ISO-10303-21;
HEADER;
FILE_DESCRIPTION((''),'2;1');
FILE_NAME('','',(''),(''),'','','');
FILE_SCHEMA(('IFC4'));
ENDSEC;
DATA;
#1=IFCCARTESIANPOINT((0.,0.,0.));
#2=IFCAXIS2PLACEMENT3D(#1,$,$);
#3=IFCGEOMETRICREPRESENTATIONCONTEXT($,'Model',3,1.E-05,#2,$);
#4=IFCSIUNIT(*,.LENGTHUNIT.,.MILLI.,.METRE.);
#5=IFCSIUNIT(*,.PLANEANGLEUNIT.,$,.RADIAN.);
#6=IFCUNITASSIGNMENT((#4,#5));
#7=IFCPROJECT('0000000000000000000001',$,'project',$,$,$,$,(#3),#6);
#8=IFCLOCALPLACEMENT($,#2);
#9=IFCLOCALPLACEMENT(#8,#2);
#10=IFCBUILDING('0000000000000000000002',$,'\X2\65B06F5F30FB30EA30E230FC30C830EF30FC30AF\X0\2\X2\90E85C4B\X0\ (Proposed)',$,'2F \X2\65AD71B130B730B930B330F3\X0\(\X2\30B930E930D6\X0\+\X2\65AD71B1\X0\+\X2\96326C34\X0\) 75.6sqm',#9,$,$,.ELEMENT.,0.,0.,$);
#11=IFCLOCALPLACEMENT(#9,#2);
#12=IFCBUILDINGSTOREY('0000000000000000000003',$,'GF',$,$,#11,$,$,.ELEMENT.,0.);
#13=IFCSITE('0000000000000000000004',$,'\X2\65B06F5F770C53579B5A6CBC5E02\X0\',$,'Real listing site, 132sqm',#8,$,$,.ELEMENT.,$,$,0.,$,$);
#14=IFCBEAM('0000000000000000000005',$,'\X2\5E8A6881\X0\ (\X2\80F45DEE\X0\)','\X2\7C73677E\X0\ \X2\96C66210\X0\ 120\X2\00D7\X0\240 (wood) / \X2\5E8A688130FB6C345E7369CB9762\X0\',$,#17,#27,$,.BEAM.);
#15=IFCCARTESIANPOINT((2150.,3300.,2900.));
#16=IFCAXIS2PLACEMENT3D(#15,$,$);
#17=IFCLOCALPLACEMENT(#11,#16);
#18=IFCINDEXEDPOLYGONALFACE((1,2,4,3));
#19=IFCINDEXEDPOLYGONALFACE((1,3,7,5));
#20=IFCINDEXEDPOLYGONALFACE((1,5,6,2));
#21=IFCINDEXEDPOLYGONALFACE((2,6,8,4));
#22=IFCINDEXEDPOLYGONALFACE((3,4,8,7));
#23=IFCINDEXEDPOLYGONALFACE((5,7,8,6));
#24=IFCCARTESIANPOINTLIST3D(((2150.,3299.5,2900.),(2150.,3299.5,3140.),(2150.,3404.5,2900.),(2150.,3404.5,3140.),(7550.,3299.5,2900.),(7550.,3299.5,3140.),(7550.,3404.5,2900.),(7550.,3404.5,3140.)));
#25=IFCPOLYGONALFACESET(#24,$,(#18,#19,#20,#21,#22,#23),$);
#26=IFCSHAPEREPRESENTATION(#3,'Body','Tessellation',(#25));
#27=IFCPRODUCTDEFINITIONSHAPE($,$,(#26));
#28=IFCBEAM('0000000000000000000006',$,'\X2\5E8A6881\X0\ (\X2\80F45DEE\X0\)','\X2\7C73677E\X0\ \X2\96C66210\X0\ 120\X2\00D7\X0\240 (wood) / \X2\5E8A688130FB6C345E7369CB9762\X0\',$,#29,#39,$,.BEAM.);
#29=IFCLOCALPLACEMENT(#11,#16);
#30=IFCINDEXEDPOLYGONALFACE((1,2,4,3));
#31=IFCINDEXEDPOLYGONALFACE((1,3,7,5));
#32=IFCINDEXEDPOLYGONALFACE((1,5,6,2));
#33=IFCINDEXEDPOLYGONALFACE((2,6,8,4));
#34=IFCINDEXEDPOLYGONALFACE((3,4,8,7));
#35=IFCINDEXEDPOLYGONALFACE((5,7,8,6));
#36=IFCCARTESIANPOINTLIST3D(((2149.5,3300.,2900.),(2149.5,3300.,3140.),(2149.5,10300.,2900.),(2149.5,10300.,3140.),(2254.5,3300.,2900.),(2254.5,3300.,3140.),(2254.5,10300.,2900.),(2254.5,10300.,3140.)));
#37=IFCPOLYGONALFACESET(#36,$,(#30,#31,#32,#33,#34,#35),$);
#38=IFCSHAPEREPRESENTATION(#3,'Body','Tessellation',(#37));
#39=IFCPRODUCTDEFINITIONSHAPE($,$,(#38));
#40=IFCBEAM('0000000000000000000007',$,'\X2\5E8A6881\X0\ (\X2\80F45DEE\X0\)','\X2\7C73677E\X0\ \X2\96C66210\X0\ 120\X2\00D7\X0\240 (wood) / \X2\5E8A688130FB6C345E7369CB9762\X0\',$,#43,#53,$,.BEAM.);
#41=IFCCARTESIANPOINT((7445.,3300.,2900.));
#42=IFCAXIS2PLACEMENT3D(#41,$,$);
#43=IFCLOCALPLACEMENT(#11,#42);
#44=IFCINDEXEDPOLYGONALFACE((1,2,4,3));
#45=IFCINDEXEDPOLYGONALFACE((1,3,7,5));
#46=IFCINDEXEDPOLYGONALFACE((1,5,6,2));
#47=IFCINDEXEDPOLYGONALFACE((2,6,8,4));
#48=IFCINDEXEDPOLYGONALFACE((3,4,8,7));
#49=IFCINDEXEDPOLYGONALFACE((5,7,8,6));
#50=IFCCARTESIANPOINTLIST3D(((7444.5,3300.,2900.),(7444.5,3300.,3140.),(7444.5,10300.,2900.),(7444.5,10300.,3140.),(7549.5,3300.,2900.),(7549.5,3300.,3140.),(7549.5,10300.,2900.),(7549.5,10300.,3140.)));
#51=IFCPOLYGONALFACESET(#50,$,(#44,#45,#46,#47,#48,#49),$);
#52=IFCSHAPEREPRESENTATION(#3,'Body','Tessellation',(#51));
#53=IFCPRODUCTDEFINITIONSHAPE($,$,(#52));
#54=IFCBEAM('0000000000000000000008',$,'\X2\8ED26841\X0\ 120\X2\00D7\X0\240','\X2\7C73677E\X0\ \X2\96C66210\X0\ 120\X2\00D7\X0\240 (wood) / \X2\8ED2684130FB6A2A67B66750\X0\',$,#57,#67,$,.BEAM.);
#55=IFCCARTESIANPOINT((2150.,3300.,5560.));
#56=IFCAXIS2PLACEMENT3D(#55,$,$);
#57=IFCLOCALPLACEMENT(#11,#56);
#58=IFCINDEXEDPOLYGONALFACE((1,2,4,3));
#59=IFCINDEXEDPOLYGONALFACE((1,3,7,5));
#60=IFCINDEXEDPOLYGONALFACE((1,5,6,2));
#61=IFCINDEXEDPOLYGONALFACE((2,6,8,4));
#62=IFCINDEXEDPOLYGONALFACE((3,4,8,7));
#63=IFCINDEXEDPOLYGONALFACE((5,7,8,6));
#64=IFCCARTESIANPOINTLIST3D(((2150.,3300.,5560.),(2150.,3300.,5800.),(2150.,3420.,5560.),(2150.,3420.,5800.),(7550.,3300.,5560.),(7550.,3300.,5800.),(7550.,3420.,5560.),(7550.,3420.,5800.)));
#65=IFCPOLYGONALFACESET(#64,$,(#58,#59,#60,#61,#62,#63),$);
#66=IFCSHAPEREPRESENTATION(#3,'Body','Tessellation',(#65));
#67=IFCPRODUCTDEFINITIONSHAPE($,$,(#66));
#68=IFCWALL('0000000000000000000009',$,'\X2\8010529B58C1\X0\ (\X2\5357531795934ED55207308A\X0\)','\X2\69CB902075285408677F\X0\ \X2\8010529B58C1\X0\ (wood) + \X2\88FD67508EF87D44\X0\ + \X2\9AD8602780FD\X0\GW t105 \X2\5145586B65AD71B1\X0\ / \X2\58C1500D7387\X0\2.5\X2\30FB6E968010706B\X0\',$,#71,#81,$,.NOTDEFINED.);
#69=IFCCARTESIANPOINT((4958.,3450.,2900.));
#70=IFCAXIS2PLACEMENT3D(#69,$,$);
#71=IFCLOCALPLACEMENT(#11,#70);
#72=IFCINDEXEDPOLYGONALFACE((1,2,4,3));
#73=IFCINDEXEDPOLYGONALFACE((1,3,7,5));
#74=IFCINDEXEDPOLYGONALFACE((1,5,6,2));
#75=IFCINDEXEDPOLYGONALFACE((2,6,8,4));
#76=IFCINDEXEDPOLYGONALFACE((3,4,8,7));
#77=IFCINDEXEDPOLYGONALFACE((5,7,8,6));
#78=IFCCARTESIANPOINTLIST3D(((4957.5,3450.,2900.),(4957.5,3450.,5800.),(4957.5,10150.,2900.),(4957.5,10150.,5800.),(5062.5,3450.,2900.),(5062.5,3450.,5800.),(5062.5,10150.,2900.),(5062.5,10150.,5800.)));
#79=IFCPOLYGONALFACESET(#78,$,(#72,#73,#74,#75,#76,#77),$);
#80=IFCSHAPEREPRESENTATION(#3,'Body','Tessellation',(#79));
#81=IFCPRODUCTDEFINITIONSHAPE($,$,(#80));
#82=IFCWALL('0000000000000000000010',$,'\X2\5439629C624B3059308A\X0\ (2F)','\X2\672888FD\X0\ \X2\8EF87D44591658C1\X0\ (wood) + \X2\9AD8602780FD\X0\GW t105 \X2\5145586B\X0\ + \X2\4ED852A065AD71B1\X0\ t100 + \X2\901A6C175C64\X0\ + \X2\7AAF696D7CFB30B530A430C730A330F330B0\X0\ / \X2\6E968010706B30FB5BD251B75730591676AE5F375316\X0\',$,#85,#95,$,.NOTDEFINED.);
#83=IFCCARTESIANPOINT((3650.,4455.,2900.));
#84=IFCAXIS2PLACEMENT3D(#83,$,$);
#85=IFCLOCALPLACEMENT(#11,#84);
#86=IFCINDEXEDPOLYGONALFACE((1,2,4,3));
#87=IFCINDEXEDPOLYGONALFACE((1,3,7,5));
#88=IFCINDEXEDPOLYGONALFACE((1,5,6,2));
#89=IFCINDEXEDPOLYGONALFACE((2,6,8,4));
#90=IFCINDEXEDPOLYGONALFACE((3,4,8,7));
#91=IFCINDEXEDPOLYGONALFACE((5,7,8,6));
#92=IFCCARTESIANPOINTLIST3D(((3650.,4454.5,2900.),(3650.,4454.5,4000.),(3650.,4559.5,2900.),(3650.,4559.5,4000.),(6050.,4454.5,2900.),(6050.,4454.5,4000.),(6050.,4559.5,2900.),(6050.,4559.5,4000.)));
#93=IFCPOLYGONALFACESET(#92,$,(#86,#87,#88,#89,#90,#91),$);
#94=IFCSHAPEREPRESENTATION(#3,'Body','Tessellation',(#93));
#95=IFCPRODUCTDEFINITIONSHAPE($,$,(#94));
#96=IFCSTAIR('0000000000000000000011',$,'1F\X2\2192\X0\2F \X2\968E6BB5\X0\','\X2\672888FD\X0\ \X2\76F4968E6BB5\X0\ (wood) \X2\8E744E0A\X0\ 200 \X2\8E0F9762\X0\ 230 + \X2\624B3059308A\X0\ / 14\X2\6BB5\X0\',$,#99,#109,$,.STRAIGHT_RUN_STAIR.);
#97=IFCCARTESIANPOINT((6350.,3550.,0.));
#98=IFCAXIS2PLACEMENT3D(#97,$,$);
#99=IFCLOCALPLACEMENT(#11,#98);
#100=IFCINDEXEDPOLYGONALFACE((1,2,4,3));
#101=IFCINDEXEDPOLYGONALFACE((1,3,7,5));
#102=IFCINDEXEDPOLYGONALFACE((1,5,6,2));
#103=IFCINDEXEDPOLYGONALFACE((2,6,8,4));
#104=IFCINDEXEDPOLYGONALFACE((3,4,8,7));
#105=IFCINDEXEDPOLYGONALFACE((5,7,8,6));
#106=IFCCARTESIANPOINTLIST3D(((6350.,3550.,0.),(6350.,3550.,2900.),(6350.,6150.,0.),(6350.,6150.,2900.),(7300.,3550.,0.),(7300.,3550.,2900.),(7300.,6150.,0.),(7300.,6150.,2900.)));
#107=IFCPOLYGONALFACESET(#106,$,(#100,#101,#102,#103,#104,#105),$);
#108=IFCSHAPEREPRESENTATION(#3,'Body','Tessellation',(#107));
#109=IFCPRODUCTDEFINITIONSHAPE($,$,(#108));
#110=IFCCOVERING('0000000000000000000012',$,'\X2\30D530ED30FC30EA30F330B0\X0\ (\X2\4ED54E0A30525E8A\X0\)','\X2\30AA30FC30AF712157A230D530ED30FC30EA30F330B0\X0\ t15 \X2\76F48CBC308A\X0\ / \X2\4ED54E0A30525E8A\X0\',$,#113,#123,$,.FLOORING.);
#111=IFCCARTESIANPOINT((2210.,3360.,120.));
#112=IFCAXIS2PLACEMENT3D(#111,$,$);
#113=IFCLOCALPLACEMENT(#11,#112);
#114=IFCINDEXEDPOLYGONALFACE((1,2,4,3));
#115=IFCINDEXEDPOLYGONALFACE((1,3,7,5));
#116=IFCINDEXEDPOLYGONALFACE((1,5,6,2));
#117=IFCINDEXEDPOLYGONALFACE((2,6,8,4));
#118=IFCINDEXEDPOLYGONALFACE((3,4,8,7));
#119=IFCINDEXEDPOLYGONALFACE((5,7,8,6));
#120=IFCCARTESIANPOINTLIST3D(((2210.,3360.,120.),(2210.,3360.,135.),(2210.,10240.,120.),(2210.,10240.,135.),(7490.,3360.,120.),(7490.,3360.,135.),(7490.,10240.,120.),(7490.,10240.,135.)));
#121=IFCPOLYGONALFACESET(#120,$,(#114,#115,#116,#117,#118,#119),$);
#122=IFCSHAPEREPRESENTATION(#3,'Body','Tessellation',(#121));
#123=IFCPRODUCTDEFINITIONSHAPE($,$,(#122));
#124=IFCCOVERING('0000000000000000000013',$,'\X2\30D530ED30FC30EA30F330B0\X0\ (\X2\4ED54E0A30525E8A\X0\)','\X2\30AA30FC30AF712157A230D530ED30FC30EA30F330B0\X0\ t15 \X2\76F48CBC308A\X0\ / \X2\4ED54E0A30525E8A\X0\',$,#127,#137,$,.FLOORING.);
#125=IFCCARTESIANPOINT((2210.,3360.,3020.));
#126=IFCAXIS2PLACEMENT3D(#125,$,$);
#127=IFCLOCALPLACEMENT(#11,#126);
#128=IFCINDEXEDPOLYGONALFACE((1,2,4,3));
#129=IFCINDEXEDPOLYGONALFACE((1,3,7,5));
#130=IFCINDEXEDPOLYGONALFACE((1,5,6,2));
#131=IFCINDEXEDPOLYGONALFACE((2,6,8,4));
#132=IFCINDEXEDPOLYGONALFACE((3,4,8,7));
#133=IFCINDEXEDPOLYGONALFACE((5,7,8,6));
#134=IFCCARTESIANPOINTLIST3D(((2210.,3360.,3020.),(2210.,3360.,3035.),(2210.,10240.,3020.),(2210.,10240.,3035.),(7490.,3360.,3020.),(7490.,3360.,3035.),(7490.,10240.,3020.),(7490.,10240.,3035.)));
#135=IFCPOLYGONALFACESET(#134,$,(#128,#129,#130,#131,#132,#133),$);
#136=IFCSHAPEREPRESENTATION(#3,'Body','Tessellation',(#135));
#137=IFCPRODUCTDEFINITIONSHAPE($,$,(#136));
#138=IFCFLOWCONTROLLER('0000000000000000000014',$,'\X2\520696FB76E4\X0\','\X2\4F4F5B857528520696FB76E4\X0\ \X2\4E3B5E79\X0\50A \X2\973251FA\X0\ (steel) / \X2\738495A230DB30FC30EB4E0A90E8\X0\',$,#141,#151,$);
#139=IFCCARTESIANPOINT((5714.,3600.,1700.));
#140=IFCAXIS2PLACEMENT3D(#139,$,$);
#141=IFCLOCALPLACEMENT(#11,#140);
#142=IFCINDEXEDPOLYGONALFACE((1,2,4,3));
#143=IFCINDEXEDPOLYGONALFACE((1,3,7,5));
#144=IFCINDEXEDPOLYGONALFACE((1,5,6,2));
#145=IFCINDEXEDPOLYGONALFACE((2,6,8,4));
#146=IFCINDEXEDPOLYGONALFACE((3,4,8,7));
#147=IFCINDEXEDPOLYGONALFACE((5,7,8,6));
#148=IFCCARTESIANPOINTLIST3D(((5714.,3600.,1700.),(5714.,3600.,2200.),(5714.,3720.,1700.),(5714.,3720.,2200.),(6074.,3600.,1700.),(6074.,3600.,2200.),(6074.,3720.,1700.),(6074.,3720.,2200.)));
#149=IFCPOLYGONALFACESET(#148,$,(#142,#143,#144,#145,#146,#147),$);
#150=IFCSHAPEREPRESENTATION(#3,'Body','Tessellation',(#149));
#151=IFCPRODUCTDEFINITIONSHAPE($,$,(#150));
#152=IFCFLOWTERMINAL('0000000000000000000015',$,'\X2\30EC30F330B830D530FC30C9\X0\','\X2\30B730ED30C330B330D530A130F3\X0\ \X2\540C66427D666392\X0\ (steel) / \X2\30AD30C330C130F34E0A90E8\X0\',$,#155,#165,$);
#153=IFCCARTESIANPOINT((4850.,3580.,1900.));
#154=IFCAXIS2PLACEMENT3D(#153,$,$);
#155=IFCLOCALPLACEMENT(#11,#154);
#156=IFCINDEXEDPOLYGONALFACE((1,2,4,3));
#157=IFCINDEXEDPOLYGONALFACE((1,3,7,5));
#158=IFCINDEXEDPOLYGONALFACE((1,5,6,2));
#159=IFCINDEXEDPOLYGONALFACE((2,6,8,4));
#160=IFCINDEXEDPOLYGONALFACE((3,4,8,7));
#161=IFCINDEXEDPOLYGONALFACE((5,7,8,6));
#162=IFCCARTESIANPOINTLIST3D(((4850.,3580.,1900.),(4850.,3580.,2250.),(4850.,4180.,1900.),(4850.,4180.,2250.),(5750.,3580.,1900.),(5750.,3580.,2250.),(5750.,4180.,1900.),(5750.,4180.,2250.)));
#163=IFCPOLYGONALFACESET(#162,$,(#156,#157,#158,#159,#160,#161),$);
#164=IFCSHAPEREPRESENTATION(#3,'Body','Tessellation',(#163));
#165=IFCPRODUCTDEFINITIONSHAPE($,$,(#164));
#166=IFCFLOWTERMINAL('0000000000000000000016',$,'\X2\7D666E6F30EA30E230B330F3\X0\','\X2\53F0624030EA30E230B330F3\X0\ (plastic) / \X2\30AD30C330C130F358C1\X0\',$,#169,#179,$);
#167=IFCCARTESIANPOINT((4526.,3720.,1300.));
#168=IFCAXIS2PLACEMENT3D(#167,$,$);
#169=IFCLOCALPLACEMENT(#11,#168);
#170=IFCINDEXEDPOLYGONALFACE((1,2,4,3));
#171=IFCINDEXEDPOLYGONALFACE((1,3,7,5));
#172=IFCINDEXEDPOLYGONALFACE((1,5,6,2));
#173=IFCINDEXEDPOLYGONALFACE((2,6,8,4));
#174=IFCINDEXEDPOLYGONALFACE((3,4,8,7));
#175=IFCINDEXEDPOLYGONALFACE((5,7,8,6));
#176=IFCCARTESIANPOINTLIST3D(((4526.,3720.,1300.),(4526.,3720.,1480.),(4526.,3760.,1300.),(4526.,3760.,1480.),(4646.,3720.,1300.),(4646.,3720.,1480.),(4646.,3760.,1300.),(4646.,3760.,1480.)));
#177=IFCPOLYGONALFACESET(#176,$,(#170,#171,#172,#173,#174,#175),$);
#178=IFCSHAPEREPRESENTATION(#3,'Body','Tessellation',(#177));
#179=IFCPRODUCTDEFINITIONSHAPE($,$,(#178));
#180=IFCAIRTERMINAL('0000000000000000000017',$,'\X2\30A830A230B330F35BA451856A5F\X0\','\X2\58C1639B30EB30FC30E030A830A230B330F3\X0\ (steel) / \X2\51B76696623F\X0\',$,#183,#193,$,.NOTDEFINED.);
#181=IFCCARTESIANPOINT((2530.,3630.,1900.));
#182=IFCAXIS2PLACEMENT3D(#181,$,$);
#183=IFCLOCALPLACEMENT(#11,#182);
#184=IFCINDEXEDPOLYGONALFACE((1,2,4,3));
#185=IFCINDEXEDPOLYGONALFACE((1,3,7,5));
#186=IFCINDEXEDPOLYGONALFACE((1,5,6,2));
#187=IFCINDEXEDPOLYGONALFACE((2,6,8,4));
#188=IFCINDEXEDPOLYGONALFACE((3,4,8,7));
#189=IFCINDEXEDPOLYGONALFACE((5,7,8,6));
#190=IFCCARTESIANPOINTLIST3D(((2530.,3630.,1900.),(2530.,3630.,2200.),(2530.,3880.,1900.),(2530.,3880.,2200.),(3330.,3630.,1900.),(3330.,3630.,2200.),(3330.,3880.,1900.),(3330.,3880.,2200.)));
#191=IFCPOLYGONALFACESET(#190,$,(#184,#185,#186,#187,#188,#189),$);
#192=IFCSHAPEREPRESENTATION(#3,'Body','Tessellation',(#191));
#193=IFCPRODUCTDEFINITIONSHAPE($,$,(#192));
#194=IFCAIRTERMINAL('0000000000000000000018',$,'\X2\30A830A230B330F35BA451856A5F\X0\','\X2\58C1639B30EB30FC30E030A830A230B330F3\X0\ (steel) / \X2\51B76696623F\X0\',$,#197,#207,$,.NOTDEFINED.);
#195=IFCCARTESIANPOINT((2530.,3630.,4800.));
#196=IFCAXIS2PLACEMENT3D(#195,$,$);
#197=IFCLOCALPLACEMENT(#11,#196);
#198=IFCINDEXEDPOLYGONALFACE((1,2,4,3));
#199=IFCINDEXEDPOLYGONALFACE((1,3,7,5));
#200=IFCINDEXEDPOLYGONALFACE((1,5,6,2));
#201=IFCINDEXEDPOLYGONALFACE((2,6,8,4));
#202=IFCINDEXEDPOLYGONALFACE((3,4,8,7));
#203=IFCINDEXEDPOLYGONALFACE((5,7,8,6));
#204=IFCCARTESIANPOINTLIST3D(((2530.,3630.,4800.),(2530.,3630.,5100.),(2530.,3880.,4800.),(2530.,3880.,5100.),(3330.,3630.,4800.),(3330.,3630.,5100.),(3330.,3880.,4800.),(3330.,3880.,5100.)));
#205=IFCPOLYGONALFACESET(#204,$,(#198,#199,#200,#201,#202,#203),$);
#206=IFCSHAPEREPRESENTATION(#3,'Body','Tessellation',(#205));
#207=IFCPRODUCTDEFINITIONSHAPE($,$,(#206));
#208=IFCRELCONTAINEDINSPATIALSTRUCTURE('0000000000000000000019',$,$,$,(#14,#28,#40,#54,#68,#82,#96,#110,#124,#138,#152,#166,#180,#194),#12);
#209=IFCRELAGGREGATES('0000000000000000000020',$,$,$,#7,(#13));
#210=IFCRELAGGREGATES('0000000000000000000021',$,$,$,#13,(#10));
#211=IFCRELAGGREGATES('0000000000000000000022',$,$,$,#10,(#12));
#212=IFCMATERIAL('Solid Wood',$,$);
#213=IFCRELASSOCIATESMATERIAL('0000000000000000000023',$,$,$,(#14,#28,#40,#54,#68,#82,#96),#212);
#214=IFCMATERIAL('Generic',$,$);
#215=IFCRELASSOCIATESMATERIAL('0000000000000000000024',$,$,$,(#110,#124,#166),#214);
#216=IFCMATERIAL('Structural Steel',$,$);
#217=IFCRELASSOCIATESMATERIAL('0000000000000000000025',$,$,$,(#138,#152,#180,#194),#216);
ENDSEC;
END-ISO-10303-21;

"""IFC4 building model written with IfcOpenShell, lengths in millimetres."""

from ifc_helpers import new_model, si_unit, frame, frame_2d, origin, place, context, project, spatial, rectangle, extrude, material, element, save


model = new_model("IFC4")

# Units and contexts
model_context = context("Model", 3, precision=1e-05, world=origin())
ifc_project = project(units=[si_unit("LENGTHUNIT", "METRE", prefix="MILLI"), si_unit("PLANEANGLEUNIT", "RADIAN")], contexts=[model_context])

# Site, building, storey
site_placement = place(None, origin())
site = spatial("IfcSite", under=ifc_project, at=site_placement, Name="新潟県南魚沼市", ObjectType="Real listing site, 132sqm", CompositionType="ELEMENT", RefElevation=0.0)
building_placement = place(site_placement, origin())
building = spatial("IfcBuilding", under=site, at=building_placement, Name="新潟・リモートワーク2部屋 (Proposed)", ObjectType="2F 断熱シスコン(スラブ+断熱+防水) 75.6sqm", CompositionType="ELEMENT", ElevationOfRefHeight=0.0, ElevationOfTerrain=0.0)
storey_placement = place(building_placement, origin())
storey = spatial("IfcBuildingStorey", under=building, at=storey_placement, Name="GF", CompositionType="ELEMENT", Elevation=0.0)

# Shared definitions
ifc_material_1 = material(Name="Solid Wood")

# Beams
beam_1_placement = place(storey_placement, frame((2150.0, 3300.0, 2900.0)))
element("IfcBeam", 1, at=beam_1_placement, inside=storey, material=ifc_material_1, Name="床梁 (胴差)", Description="米松 集成 120×240 (wood) / 床梁・水平構面", PredefinedType="BEAM", context=model_context, shape_type="SweptSolid", body=[
    extrude(rectangle(XDim=5400.0, YDim=105.0, at=frame_2d((2700.0, 52.0))), frame((2150.0, 3300.0, 2900.0)), (0.0, 0.0, 1.0), 240.0),
])
beam_2_placement = place(storey_placement, frame((2150.0, 3300.0, 2900.0)))
element("IfcBeam", 2, at=beam_2_placement, inside=storey, material=ifc_material_1, Name="床梁 (胴差)", Description="米松 集成 120×240 (wood) / 床梁・水平構面", PredefinedType="BEAM", context=model_context, shape_type="SweptSolid", body=[
    extrude(rectangle(XDim=105.0, YDim=7000.0, at=frame_2d((52.0, 3500.0))), frame((2150.0, 3300.0, 2900.0)), (0.0, 0.0, 1.0), 240.0),
])
beam_3_placement = place(storey_placement, frame((7445.0, 3300.0, 2900.0)))
element("IfcBeam", 3, at=beam_3_placement, inside=storey, material=ifc_material_1, Name="床梁 (胴差)", Description="米松 集成 120×240 (wood) / 床梁・水平構面", PredefinedType="BEAM", context=model_context, shape_type="SweptSolid", body=[
    extrude(rectangle(XDim=105.0, YDim=7000.0, at=frame_2d((52.0, 3500.0))), frame((7445.0, 3300.0, 2900.0)), (0.0, 0.0, 1.0), 240.0),
])
beam_4_placement = place(storey_placement, frame((2150.0, 3300.0, 5560.0)))
element("IfcBeam", 4, at=beam_4_placement, inside=storey, material=ifc_material_1, Name="軒桁 120×240", Description="米松 集成 120×240 (wood) / 軒桁・横架材", PredefinedType="BEAM", context=model_context, shape_type="SweptSolid", body=[
    extrude(rectangle(XDim=5400.0, YDim=120.0, at=frame_2d((2700.0, 60.0))), frame((2150.0, 3300.0, 5560.0)), (0.0, 0.0, 1.0), 240.0),
])

# Walls
wall_1_placement = place(storey_placement, frame((4958.0, 3450.0, 2900.0)))
element("IfcWall", 5, at=wall_1_placement, inside=storey, material=ifc_material_1, Name="耐力壁 (南北間仕切り)", Description="構造用合板 耐力壁 (wood) + 製材軸組 + 高性能GW t105 充填断熱 / 壁倍率2.5・準耐火", PredefinedType="NOTDEFINED", context=model_context, shape_type="SweptSolid", body=[
    extrude(rectangle(XDim=105.0, YDim=6700.0, at=frame_2d((52.0, 3350.0))), frame((4958.0, 3450.0, 2900.0)), (0.0, 0.0, 1.0), 2900.0),
])
wall_2_placement = place(storey_placement, frame((3650.0, 4455.0, 2900.0)))
element("IfcWall", 6, at=wall_2_placement, inside=storey, material=ifc_material_1, Name="吹抜手すり (2F)", Description="木製 軸組外壁 (wood) + 高性能GW t105 充填 + 付加断熱 t100 + 通気層 + 窯業系サイディング / 準耐火・寒冷地外皮強化", PredefinedType="NOTDEFINED", context=model_context, shape_type="SweptSolid", body=[
    extrude(rectangle(XDim=2400.0, YDim=105.0, at=frame_2d((1200.0, 52.0))), frame((3650.0, 4455.0, 2900.0)), (0.0, 0.0, 1.0), 1100.0),
])

# Stair
stair_placement = place(storey_placement, frame((6350.0, 3550.0, 0.0)))
element("IfcStair", 7, at=stair_placement, inside=storey, material=ifc_material_1, Name="1F→2F 階段", Description="木製 直階段 (wood) 蹴上 200 踏面 230 + 手すり / 14段", PredefinedType="STRAIGHT_RUN_STAIR", context=model_context, shape_type="SweptSolid", body=[
    extrude(rectangle(XDim=950.0, YDim=2600.0, at=frame_2d((475.0, 1300.0))), frame((6350.0, 3550.0, 0.0)), (0.0, 0.0, 1.0), 2900.0),
])

# Coverings
ifc_material_2 = material(Name="Generic")
covering_1_placement = place(storey_placement, frame((2210.0, 3360.0, 120.0)))
element("IfcCovering", 8, at=covering_1_placement, inside=storey, material=ifc_material_2, Name="フローリング (仕上げ床)", Description="オーク無垢フローリング t15 直貼り / 仕上げ床", PredefinedType="FLOORING", context=model_context, shape_type="SweptSolid", body=[
    extrude(rectangle(XDim=5280.0, YDim=6880.0, at=frame_2d((2640.0, 3440.0))), frame((2210.0, 3360.0, 120.0)), (0.0, 0.0, 1.0), 15.0),
])
covering_2_placement = place(storey_placement, frame((2210.0, 3360.0, 3020.0)))
element("IfcCovering", 9, at=covering_2_placement, inside=storey, material=ifc_material_2, Name="フローリング (仕上げ床)", Description="オーク無垢フローリング t15 直貼り / 仕上げ床", PredefinedType="FLOORING", context=model_context, shape_type="SweptSolid", body=[
    extrude(rectangle(XDim=5280.0, YDim=6880.0, at=frame_2d((2640.0, 3440.0))), frame((2210.0, 3360.0, 3020.0)), (0.0, 0.0, 1.0), 15.0),
])

# Flow controller
ifc_material_3 = material(Name="Structural Steel")
flow_controller_placement = place(storey_placement, frame((5714.0, 3600.0, 1700.0)))
element("IfcFlowController", 10, at=flow_controller_placement, inside=storey, material=ifc_material_3, Name="分電盤", Description="住宅用分電盤 主幹50A 露出 (steel) / 玄関ホール上部", context=model_context, shape_type="SweptSolid", body=[
    extrude(rectangle(XDim=360.0, YDim=120.0, at=frame_2d((180.0, 60.0))), frame((5714.0, 3600.0, 1700.0)), (0.0, 0.0, 1.0), 500.0),
])

# Flow terminals
flow_terminal_1_placement = place(storey_placement, frame((4850.0, 3580.0, 1900.0)))
element("IfcFlowTerminal", 11, at=flow_terminal_1_placement, inside=storey, material=ifc_material_3, Name="レンジフード", Description="シロッコファン 同時給排 (steel) / キッチン上部", context=model_context, shape_type="SweptSolid", body=[
    extrude(rectangle(XDim=900.0, YDim=600.0, at=frame_2d((450.0, 300.0))), frame((4850.0, 3580.0, 1900.0)), (0.0, 0.0, 1.0), 350.0),
])
flow_terminal_2_placement = place(storey_placement, frame((4526.0, 3720.0, 1300.0)))
element("IfcFlowTerminal", 12, at=flow_terminal_2_placement, inside=storey, material=ifc_material_2, Name="給湯リモコン", Description="台所リモコン (plastic) / キッチン壁", context=model_context, shape_type="SweptSolid", body=[
    extrude(rectangle(XDim=120.0, YDim=40.0, at=frame_2d((60.0, 20.0))), frame((4526.0, 3720.0, 1300.0)), (0.0, 0.0, 1.0), 180.0),
])

# Air terminals
air_terminal_1_placement = place(storey_placement, frame((2530.0, 3630.0, 1900.0)))
element("IfcAirTerminal", 13, at=air_terminal_1_placement, inside=storey, material=ifc_material_3, Name="エアコン室内機", Description="壁掛ルームエアコン (steel) / 冷暖房", PredefinedType="NOTDEFINED", context=model_context, shape_type="SweptSolid", body=[
    extrude(rectangle(XDim=800.0, YDim=250.0, at=frame_2d((400.0, 125.0))), frame((2530.0, 3630.0, 1900.0)), (0.0, 0.0, 1.0), 300.0),
])
air_terminal_2_placement = place(storey_placement, frame((2530.0, 3630.0, 4800.0)))
element("IfcAirTerminal", 14, at=air_terminal_2_placement, inside=storey, material=ifc_material_3, Name="エアコン室内機", Description="壁掛ルームエアコン (steel) / 冷暖房", PredefinedType="NOTDEFINED", context=model_context, shape_type="SweptSolid", body=[
    extrude(rectangle(XDim=800.0, YDim=250.0, at=frame_2d((400.0, 125.0))), frame((2530.0, 3630.0, 4800.0)), (0.0, 0.0, 1.0), 300.0),
])

save(model, "model.ifc")
